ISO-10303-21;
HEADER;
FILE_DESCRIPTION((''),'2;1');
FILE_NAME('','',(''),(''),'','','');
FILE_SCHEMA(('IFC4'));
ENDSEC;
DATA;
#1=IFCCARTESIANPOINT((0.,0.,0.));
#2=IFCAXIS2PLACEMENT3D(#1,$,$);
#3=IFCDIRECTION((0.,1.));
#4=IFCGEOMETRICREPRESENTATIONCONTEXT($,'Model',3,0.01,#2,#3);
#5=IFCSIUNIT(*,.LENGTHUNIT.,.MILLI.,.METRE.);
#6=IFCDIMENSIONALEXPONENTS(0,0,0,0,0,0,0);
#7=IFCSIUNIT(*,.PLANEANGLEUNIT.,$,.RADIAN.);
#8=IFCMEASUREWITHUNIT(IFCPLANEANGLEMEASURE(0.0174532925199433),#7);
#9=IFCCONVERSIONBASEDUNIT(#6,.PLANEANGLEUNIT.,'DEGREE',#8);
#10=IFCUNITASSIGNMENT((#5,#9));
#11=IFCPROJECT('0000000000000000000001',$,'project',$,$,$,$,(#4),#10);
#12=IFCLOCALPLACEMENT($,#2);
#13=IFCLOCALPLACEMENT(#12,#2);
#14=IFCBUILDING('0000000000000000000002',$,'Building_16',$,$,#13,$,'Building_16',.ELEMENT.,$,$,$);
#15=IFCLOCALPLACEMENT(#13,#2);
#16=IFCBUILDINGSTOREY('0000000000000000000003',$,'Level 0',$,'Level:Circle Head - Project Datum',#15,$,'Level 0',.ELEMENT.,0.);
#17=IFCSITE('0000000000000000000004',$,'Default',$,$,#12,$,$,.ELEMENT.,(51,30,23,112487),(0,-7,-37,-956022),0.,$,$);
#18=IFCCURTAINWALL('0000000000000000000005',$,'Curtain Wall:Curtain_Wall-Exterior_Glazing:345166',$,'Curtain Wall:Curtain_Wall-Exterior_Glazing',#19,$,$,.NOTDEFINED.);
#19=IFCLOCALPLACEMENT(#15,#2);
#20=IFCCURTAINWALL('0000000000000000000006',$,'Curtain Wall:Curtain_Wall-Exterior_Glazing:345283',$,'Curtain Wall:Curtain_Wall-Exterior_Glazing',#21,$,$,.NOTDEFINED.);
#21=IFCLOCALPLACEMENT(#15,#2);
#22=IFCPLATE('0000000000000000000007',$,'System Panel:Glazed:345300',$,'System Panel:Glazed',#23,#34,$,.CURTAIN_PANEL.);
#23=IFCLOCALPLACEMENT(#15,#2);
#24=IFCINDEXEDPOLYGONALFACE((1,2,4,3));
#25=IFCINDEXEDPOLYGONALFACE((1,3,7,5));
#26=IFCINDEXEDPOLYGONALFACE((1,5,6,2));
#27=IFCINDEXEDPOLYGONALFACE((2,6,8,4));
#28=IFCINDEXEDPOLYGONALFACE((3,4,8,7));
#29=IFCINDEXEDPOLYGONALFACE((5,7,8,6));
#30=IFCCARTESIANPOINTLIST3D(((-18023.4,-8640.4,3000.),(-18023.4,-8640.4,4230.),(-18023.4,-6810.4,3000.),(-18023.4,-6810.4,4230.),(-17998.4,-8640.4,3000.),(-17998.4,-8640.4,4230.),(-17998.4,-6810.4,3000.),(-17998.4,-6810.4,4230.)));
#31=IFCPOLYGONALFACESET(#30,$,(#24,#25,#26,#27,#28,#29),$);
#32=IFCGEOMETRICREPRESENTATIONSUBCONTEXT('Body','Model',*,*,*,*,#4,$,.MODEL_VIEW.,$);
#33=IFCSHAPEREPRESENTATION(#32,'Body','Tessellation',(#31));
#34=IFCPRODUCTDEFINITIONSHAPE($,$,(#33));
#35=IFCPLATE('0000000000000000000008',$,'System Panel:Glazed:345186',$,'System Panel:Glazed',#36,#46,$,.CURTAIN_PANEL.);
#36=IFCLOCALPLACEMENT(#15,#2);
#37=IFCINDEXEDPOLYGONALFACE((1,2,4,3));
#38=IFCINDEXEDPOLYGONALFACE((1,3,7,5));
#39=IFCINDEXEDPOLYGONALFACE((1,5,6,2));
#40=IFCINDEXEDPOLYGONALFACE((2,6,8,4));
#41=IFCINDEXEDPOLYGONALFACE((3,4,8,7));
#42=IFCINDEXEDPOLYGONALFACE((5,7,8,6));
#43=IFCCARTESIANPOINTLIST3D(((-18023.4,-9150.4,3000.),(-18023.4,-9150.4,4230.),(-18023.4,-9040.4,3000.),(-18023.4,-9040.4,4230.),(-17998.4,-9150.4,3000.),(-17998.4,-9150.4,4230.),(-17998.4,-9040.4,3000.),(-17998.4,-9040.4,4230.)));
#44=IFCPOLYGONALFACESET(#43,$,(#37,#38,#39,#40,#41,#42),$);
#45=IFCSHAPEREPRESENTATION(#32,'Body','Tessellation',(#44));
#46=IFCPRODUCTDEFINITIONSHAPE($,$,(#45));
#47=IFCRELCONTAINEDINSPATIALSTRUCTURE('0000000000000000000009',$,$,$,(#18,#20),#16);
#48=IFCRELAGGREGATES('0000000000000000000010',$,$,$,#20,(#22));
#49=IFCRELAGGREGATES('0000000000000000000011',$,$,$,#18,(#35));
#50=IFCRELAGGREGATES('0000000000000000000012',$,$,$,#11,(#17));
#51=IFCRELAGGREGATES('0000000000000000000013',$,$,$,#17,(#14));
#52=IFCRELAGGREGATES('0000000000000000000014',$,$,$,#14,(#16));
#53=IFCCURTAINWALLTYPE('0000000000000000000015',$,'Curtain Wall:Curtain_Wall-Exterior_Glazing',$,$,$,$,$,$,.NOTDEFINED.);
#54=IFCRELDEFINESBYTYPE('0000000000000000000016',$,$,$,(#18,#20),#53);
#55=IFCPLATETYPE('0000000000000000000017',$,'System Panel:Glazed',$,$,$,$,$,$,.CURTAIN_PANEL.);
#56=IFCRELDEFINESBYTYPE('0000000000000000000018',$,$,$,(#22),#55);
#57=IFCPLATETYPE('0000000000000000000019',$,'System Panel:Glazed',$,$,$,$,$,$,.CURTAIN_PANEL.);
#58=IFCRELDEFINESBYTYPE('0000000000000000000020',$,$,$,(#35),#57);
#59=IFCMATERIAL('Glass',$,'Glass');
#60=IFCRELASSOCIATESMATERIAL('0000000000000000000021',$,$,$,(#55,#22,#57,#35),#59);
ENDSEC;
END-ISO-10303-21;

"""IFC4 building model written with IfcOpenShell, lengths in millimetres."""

from ifc_helpers import new_model, entity, si_unit, converted_unit, direction, frame, origin, place, context, subcontext, project, spatial, indexed_curve, outline, extrude, source, transform, mapped, material, type_object, type_shapes, element, aggregate, save


model = new_model("IFC4")

# Units and contexts
model_context = context("Model", 3, precision=0.01, world=origin(), true_north=direction((0.0, 1.0)))
body_context = subcontext(model_context, "Body", "Model", "MODEL_VIEW")
ifc_project = project(units=[si_unit("LENGTHUNIT", "METRE", prefix="MILLI"), converted_unit("PLANEANGLEUNIT", "DEGREE", entity("IfcPlaneAngleMeasure", 0.0174532925199433), si_unit("PLANEANGLEUNIT", "RADIAN"), dimensions=[0, 0, 0, 0, 0, 0, 0])], contexts=[model_context])

# Site, building, storey
site_placement = place(None, origin())
site = spatial("IfcSite", under=ifc_project, at=site_placement, Name="Default", CompositionType="ELEMENT", RefLatitude=(51, 30, 23, 112487), RefLongitude=(0, -7, -37, -956022), RefElevation=0.0)
building_placement = place(site_placement, origin())
building = spatial("IfcBuilding", under=site, at=building_placement, Name="Building_16", LongName="Building_16", CompositionType="ELEMENT")
storey_placement = place(building_placement, origin())
storey = spatial("IfcBuildingStorey", under=building, at=storey_placement, Name="Level 0", ObjectType="Level:Circle Head - Project Datum", LongName="Level 0", CompositionType="ELEMENT", Elevation=0.0)

# Curtain walls
curtain_wall_type = type_object("IfcCurtainWallType", Name="Curtain Wall:Curtain_Wall-Exterior_Glazing", PredefinedType="NOTDEFINED")
curtain_wall_1_placement = place(storey_placement, origin())
curtain_wall_1 = element("IfcCurtainWall", 1, at=curtain_wall_1_placement, inside=storey, type_object=curtain_wall_type, Name="Curtain Wall:Curtain_Wall-Exterior_Glazing:345166", ObjectType="Curtain Wall:Curtain_Wall-Exterior_Glazing", PredefinedType="NOTDEFINED")
ifc_material_1 = material(Name="Glass", Category="Glass")
curtain_wall_2_placement = place(storey_placement, origin())
curtain_wall_2 = element("IfcCurtainWall", 2, at=curtain_wall_2_placement, inside=storey, type_object=curtain_wall_type, Name="Curtain Wall:Curtain_Wall-Exterior_Glazing:345283", ObjectType="Curtain Wall:Curtain_Wall-Exterior_Glazing", PredefinedType="NOTDEFINED")

# Plates
plate_type_1 = type_object("IfcPlateType", Name="System Panel:Glazed", PredefinedType="CURTAIN_PANEL", material=ifc_material_1)
shared_shape_1 = source(origin(), body_context, "Body", "SweptSolid", [
    extrude(outline(indexed_curve([(-12.5, -915.0), (12.5, -915.0), (12.5, 915.0), (-12.5, 915.0), (-12.5, -915.0)], self_intersect=False)), frame((0.0, 37.0, 0.0), z_axis=(0.0, 0.0, 1.0), x_axis=(0.0, 1.0, 0.0)), (0.0, 0.0, 1.0), 1230.0),
])
type_shapes(plate_type_1, [shared_shape_1])
plate_1_placement = place(curtain_wall_2_placement, frame((-17973.9, -7725.4, 3000.0), z_axis=(0.0, 0.0, 1.0), x_axis=(0.0, 1.0, 0.0)))
plate_1 = element("IfcPlate", 3, at=plate_1_placement, type_object=plate_type_1, material=ifc_material_1, Name="System Panel:Glazed:345300", ObjectType="System Panel:Glazed", PredefinedType="CURTAIN_PANEL", context=body_context, shape_type="MappedRepresentation", body=[
    mapped(shared_shape_1, transform((0.0, 0.0, 0.0), scale=1.0)),
])
aggregate(curtain_wall_2, [plate_1])
plate_type_2 = type_object("IfcPlateType", Name="System Panel:Glazed", PredefinedType="CURTAIN_PANEL", material=ifc_material_1)
shared_shape_2 = source(origin(), body_context, "Body", "SweptSolid", [
    extrude(outline(indexed_curve([(-12.5, -55.0), (12.5, -55.0), (12.5, 55.0), (-12.5, 55.0), (-12.5, -55.0)], self_intersect=False)), frame((0.0, 37.0, 0.0), z_axis=(0.0, 0.0, 1.0), x_axis=(0.0, 1.0, 0.0)), (0.0, 0.0, 1.0), 1230.0),
])
type_shapes(plate_type_2, [shared_shape_2])
plate_2_placement = place(curtain_wall_1_placement, frame((-17973.9, -9095.4, 3000.0), z_axis=(0.0, 0.0, 1.0), x_axis=(0.0, 1.0, 0.0)))
plate_2 = element("IfcPlate", 4, at=plate_2_placement, type_object=plate_type_2, material=ifc_material_1, Name="System Panel:Glazed:345186", ObjectType="System Panel:Glazed", PredefinedType="CURTAIN_PANEL", context=body_context, shape_type="MappedRepresentation", body=[
    mapped(shared_shape_2, transform((0.0, 0.0, 0.0), scale=1.0)),
])
aggregate(curtain_wall_1, [plate_2])

save(model, "model.ifc")
